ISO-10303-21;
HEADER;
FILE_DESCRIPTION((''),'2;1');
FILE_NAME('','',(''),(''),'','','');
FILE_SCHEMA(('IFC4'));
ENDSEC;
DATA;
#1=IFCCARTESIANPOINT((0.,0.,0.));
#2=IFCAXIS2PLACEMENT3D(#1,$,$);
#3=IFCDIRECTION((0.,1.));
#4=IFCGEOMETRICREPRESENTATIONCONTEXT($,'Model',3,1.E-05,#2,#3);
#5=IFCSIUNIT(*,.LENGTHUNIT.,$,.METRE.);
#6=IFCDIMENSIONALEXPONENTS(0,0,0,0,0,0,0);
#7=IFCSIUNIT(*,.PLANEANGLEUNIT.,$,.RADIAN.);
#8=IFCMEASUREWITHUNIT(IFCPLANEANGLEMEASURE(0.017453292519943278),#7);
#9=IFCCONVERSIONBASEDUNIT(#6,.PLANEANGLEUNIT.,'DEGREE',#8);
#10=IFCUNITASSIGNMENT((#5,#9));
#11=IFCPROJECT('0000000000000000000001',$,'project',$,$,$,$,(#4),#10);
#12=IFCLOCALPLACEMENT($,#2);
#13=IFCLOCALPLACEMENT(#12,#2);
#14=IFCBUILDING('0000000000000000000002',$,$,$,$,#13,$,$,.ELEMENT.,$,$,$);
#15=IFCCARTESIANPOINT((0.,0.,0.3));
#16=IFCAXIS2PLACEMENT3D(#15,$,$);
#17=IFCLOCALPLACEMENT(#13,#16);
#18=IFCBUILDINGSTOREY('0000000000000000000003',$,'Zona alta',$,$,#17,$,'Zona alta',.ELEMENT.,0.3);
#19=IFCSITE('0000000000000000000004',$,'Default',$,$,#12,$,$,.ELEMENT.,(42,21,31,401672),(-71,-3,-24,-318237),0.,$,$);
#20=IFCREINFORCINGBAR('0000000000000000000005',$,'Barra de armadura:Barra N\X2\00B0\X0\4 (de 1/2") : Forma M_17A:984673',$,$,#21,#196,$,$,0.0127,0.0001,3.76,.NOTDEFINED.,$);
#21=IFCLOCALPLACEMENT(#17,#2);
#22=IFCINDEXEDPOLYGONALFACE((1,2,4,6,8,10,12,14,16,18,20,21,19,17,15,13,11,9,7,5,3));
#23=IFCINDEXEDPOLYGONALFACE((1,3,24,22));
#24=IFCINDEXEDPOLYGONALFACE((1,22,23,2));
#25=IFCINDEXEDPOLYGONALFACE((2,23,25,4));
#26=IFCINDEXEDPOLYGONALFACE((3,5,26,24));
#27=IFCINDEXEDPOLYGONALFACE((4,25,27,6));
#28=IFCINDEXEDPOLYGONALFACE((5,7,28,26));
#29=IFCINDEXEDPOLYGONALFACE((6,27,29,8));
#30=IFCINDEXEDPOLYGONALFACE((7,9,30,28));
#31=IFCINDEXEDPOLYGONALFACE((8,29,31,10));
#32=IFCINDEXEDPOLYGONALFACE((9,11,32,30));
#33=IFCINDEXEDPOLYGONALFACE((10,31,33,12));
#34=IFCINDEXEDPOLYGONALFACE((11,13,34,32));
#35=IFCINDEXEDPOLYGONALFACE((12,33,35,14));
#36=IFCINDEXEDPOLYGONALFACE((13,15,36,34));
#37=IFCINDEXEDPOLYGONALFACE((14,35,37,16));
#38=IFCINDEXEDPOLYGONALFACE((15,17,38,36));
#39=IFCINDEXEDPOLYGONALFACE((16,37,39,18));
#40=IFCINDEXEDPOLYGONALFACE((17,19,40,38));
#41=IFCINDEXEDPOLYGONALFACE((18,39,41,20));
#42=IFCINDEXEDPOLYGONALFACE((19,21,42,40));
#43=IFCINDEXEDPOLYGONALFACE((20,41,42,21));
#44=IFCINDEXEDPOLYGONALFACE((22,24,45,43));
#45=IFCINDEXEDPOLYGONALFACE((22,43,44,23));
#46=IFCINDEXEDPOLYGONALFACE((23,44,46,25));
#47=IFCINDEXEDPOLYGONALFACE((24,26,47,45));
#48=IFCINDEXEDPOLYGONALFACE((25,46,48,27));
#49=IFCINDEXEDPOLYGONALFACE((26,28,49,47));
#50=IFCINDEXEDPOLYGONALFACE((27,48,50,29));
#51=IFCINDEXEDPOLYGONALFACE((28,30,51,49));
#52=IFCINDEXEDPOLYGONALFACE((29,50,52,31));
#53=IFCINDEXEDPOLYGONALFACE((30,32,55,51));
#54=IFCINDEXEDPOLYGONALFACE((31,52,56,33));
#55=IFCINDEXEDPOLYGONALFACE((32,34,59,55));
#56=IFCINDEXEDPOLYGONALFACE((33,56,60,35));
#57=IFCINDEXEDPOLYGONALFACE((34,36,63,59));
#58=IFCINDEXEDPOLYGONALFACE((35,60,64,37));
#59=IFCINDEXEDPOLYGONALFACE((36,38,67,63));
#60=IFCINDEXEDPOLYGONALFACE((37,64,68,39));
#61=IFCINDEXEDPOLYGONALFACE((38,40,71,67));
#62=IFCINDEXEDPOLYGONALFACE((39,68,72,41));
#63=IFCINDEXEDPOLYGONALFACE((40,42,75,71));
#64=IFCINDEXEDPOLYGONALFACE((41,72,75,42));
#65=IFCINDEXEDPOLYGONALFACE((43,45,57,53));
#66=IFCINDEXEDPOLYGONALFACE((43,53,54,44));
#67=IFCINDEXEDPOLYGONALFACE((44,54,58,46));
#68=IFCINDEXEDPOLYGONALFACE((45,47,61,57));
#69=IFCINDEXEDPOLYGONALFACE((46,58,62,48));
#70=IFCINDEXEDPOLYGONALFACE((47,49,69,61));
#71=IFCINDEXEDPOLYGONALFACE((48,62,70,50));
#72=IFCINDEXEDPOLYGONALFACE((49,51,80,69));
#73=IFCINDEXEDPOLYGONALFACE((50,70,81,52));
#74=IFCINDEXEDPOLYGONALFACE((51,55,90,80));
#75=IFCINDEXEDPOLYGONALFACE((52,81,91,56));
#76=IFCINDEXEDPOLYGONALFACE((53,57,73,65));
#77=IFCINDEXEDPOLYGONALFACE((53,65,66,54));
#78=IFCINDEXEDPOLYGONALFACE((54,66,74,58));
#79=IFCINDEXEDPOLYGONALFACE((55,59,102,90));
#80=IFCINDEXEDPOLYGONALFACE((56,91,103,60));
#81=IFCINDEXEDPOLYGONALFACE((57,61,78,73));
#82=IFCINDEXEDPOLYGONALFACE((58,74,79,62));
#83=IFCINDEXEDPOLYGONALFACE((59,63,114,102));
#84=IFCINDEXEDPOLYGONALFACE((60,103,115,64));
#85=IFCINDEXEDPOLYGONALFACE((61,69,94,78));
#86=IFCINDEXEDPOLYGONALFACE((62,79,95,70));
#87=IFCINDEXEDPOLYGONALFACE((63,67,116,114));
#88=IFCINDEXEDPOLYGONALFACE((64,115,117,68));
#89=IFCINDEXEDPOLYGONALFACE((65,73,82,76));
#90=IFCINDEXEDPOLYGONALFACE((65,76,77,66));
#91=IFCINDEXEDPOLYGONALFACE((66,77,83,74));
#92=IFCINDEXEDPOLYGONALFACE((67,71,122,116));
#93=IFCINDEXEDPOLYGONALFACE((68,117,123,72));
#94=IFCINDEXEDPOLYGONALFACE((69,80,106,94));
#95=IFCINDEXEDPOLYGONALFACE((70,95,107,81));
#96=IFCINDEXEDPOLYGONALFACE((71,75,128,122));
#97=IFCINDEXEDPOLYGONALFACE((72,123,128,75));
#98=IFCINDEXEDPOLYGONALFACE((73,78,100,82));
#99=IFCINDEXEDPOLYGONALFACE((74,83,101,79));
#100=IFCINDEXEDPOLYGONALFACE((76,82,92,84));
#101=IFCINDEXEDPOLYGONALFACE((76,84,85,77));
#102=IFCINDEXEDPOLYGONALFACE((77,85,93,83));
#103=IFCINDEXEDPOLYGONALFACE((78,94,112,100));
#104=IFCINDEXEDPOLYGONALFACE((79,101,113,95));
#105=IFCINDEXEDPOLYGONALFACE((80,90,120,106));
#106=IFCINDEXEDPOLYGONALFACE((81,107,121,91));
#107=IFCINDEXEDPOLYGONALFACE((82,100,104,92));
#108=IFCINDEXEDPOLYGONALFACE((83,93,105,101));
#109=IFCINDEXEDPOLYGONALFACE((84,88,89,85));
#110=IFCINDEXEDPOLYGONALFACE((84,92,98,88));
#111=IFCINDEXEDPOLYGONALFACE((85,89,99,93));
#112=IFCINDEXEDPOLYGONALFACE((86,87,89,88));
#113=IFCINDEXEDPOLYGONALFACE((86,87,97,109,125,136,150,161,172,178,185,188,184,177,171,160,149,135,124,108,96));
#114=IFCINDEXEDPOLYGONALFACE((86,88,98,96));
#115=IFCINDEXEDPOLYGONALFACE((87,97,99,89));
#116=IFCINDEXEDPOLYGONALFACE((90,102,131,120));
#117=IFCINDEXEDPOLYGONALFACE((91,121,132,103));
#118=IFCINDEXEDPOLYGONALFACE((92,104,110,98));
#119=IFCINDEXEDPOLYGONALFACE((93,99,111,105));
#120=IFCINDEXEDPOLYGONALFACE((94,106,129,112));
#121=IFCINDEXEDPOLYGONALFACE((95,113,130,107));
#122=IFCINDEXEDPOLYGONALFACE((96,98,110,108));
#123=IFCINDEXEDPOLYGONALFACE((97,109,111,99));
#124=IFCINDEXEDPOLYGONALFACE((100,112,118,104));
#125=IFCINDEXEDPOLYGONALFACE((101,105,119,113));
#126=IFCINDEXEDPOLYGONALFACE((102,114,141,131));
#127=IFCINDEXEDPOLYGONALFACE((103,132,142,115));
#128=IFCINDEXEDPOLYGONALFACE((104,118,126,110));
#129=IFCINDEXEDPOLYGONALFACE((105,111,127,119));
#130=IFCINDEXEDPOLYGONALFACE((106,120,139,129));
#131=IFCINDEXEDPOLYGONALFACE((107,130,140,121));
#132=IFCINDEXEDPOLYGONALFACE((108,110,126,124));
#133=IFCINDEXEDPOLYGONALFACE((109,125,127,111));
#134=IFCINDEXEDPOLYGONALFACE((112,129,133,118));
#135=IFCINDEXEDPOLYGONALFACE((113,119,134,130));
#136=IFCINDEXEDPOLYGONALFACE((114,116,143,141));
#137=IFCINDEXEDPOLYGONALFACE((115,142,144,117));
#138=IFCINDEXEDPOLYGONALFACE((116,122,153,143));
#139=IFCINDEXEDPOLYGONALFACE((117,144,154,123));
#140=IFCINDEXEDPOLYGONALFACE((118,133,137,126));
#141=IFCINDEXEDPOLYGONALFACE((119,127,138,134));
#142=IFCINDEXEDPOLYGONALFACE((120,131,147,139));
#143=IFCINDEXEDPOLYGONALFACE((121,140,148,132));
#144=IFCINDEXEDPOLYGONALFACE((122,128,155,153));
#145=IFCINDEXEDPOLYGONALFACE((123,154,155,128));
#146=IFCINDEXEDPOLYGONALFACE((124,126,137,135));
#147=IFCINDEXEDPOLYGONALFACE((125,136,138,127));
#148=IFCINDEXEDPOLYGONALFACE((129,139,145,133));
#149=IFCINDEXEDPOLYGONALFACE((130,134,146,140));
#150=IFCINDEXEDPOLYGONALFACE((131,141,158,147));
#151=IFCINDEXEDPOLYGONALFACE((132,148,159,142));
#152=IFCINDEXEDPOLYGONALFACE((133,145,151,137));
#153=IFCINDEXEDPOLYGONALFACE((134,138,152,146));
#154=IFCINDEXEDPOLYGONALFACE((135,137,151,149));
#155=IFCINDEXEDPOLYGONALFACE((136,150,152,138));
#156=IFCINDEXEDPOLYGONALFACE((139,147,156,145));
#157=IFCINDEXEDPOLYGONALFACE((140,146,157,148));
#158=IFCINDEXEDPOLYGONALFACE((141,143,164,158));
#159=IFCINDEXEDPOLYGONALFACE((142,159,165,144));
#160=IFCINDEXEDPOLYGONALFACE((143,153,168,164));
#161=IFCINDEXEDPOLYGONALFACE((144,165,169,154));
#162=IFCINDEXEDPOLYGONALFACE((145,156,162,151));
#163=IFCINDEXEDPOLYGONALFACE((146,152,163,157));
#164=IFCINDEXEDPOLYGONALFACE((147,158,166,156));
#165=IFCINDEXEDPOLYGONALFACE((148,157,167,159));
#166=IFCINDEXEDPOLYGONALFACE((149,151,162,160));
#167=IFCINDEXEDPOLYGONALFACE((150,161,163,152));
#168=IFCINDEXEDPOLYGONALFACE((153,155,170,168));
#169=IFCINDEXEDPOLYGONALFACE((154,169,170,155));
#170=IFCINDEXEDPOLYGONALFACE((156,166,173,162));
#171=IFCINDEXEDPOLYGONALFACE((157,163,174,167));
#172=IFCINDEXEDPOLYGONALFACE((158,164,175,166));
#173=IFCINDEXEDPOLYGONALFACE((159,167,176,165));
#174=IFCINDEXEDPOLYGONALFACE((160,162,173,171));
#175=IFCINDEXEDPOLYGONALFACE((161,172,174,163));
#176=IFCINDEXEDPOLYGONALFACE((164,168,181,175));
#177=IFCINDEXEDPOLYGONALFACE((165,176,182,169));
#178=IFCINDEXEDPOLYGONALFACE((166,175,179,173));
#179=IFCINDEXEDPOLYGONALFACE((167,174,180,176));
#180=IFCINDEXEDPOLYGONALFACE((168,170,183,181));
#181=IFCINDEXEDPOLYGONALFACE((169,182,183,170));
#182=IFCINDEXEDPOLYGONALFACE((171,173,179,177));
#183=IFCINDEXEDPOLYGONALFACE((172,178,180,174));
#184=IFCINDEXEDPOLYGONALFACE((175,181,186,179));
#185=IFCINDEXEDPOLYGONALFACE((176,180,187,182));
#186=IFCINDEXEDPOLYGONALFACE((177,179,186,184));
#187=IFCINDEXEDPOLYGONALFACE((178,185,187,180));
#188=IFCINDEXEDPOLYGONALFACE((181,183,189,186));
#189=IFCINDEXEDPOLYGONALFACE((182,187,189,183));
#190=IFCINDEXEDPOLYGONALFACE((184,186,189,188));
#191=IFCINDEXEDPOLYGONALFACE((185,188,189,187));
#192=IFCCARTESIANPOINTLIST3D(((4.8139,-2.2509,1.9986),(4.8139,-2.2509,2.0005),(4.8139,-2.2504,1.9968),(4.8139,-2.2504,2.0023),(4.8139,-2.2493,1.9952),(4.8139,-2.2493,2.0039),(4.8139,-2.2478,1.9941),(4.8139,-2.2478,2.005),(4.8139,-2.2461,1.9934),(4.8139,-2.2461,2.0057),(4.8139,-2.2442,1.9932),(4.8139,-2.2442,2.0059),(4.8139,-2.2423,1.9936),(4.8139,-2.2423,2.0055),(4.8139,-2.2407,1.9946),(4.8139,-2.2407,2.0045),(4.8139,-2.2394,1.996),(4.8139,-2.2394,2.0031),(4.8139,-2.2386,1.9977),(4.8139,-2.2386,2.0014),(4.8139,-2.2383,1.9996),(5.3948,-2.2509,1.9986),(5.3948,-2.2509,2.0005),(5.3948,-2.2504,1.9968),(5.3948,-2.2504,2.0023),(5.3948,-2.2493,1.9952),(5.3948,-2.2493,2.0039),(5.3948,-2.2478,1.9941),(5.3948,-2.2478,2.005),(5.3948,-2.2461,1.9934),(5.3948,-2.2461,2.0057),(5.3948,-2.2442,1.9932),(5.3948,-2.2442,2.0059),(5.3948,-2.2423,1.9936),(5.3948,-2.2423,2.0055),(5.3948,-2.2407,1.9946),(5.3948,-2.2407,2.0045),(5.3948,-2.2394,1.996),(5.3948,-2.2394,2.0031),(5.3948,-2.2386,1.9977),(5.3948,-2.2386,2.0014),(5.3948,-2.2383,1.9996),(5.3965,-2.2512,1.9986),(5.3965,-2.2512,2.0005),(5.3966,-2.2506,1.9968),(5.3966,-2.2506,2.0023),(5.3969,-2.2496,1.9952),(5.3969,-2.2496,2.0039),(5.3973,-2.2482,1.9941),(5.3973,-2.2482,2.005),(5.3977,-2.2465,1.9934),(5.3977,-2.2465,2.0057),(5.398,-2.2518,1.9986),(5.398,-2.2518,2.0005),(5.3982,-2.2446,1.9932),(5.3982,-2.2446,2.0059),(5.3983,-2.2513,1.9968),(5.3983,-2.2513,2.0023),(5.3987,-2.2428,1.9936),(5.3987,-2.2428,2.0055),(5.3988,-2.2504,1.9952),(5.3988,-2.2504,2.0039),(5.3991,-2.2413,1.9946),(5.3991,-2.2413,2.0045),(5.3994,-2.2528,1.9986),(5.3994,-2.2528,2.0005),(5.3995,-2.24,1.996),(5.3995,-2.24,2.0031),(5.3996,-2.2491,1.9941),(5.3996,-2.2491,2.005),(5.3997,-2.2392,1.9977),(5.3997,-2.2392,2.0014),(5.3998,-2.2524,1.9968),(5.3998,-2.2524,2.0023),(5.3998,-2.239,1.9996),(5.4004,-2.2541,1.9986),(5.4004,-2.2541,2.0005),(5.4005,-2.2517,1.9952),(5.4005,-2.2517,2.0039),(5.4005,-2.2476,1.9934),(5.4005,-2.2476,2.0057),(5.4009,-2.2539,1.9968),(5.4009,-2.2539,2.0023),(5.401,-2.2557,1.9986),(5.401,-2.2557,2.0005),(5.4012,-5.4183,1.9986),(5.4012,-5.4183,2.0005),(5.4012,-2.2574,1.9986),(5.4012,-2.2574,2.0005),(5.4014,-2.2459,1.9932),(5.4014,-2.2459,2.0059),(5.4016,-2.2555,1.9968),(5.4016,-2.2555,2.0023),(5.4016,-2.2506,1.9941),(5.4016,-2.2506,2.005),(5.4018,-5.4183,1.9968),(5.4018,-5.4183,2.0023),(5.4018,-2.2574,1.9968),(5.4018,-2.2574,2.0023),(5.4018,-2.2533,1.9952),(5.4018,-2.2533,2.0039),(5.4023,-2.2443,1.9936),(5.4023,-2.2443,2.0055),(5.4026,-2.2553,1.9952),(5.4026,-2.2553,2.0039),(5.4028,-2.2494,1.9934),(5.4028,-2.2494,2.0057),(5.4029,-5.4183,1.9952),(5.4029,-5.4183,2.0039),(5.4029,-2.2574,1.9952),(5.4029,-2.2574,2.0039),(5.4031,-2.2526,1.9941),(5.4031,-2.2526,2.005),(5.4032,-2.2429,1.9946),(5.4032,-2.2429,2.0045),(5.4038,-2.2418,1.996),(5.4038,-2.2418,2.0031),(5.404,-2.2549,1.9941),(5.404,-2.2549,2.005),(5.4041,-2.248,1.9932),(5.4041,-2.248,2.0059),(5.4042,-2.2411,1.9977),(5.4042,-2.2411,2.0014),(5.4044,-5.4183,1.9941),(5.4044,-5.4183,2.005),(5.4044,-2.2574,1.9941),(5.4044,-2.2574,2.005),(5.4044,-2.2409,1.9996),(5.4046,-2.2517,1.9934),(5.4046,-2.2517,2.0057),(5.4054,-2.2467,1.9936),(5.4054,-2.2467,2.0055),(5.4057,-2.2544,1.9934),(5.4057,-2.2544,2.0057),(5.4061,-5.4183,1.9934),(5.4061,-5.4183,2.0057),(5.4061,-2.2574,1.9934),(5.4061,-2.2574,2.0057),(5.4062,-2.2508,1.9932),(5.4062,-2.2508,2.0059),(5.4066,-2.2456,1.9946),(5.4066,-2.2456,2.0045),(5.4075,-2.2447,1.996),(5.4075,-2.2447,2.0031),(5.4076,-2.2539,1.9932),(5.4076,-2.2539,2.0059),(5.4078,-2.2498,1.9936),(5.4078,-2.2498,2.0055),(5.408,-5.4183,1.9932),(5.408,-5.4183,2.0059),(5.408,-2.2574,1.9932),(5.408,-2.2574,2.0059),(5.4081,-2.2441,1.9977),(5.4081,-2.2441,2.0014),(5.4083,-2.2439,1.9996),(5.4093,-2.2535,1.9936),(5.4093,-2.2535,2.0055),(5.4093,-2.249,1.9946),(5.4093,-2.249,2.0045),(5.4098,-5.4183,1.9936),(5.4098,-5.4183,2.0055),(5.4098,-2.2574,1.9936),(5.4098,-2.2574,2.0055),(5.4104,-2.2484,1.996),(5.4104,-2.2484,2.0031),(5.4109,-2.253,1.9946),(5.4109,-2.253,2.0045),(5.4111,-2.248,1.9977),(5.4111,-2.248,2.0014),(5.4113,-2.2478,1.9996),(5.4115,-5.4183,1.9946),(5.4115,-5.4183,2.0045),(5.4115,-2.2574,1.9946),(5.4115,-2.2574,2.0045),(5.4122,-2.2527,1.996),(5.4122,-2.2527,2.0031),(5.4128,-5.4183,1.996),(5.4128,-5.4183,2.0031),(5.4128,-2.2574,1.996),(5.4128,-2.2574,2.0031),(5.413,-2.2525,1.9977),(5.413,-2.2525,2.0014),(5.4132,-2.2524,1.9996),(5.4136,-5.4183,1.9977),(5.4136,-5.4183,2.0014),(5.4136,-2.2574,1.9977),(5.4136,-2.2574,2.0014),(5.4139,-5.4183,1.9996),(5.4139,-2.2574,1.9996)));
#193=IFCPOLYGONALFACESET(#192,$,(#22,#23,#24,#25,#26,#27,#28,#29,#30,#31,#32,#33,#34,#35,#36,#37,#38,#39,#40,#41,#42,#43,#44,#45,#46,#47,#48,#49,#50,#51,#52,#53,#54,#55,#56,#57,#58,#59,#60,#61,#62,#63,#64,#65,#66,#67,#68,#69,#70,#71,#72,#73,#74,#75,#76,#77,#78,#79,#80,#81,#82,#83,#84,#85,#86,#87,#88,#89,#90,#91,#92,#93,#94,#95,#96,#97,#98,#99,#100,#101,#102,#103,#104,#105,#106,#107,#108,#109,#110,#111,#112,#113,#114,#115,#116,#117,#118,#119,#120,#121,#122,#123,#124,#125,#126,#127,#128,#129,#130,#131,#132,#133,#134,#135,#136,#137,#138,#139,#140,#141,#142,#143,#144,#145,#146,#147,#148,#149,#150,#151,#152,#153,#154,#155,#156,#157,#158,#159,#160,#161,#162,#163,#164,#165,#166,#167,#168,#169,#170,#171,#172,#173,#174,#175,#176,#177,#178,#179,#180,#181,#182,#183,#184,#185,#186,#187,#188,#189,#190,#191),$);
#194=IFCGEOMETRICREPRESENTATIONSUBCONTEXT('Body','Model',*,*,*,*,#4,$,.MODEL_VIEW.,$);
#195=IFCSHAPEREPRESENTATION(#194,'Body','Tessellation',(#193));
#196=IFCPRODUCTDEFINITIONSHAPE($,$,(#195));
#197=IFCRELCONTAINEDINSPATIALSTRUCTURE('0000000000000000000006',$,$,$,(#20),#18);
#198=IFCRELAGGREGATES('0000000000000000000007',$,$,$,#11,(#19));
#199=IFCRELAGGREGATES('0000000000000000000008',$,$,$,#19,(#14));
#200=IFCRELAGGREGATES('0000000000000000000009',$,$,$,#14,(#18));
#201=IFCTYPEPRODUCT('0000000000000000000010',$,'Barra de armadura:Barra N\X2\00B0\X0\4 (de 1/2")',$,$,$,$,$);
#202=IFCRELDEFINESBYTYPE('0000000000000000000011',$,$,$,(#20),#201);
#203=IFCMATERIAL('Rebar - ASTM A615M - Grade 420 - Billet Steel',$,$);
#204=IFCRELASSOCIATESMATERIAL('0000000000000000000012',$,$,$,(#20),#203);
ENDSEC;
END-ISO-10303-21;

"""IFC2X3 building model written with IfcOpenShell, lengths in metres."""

from ifc_helpers import new_model, entity, si_unit, converted_unit, direction, frame, origin, place, context, subcontext, project, spatial, material, type_object, element, save


model = new_model("IFC2X3")

# Units and contexts
model_context = context("Model", 3, precision=1e-05, world=origin(), true_north=direction((0.0, 1.0)))
body_context = subcontext(model_context, "Body", "Model", "MODEL_VIEW")
ifc_project = project(units=[si_unit("LENGTHUNIT", "METRE"), converted_unit("PLANEANGLEUNIT", "DEGREE", entity("IfcPlaneAngleMeasure", 0.017453292519943278), si_unit("PLANEANGLEUNIT", "RADIAN"), dimensions=[0, 0, 0, 0, 0, 0, 0])], contexts=[model_context])

# Site, building, storey
site_placement = place(None, origin())
site = spatial("IfcSite", under=ifc_project, at=site_placement, Name="Default", CompositionType="ELEMENT", RefLatitude=(42, 21, 31, 401672), RefLongitude=(-71, -3, -24, -318237), RefElevation=0.0)
building_placement = place(site_placement, origin())
building = spatial("IfcBuilding", under=site, at=building_placement, CompositionType="ELEMENT")
storey_placement = place(building_placement, frame((0.0, 0.0, 0.3)))
storey = spatial("IfcBuildingStorey", under=building, at=storey_placement, Name="Zona alta", LongName="Zona alta", CompositionType="ELEMENT", Elevation=0.3)

# Reinforcing bar
ifc_material_1 = material(Name="Rebar - ASTM A615M - Grade 420 - Billet Steel")
type_product_1 = type_object("IfcTypeProduct", Name="Barra de armadura:Barra N°4 (de 1/2\")")
reinforcing_bar_1_placement = place(storey_placement, origin())
element("IfcReinforcingBar", 1, at=reinforcing_bar_1_placement, inside=storey, type_object=type_product_1, material=ifc_material_1, Name="Barra de armadura:Barra N°4 (de 1/2\") : Forma M_17A:984673", BarLength=3.76, BarRole="NOTDEFINED", CrossSectionArea=0.0001, NominalDiameter=0.0127, context=body_context, shape_type="AdvancedSweptSolid", body=[
    entity("IfcSweptDiskSolid", entity("IfcCompositeCurve", [entity("IfcCompositeCurveSegment", "CONTINUOUS", True, entity("IfcPolyline", [entity("IfcCartesianPoint", [5.4075, -5.4183, 1.9996]), entity("IfcCartesianPoint", [5.4075, -2.2574, 1.9996])])), entity("IfcCompositeCurveSegment", "CONTINUOUS", True, entity("IfcTrimmedCurve", entity("IfcCircle", entity("IfcAxis2Placement3D", entity("IfcCartesianPoint", [5.3948, -2.2574, 1.9996]), entity("IfcDirection", [0.0, 0.0, 1.0]), entity("IfcDirection", [0.0, 1.0, 0.0])), 0.0127), [entity("IfcParameterValue", 270.0)], [entity("IfcParameterValue", 360.0)], True, "PARAMETER")), entity("IfcCompositeCurveSegment", "CONTINUOUS", True, entity("IfcPolyline", [entity("IfcCartesianPoint", [5.3948, -2.2447, 1.9996]), entity("IfcCartesianPoint", [4.8139, -2.2447, 1.9996])]))], False), 0.0063, None, 0.0, 92.0),
])

save(model, "model.ifc")
